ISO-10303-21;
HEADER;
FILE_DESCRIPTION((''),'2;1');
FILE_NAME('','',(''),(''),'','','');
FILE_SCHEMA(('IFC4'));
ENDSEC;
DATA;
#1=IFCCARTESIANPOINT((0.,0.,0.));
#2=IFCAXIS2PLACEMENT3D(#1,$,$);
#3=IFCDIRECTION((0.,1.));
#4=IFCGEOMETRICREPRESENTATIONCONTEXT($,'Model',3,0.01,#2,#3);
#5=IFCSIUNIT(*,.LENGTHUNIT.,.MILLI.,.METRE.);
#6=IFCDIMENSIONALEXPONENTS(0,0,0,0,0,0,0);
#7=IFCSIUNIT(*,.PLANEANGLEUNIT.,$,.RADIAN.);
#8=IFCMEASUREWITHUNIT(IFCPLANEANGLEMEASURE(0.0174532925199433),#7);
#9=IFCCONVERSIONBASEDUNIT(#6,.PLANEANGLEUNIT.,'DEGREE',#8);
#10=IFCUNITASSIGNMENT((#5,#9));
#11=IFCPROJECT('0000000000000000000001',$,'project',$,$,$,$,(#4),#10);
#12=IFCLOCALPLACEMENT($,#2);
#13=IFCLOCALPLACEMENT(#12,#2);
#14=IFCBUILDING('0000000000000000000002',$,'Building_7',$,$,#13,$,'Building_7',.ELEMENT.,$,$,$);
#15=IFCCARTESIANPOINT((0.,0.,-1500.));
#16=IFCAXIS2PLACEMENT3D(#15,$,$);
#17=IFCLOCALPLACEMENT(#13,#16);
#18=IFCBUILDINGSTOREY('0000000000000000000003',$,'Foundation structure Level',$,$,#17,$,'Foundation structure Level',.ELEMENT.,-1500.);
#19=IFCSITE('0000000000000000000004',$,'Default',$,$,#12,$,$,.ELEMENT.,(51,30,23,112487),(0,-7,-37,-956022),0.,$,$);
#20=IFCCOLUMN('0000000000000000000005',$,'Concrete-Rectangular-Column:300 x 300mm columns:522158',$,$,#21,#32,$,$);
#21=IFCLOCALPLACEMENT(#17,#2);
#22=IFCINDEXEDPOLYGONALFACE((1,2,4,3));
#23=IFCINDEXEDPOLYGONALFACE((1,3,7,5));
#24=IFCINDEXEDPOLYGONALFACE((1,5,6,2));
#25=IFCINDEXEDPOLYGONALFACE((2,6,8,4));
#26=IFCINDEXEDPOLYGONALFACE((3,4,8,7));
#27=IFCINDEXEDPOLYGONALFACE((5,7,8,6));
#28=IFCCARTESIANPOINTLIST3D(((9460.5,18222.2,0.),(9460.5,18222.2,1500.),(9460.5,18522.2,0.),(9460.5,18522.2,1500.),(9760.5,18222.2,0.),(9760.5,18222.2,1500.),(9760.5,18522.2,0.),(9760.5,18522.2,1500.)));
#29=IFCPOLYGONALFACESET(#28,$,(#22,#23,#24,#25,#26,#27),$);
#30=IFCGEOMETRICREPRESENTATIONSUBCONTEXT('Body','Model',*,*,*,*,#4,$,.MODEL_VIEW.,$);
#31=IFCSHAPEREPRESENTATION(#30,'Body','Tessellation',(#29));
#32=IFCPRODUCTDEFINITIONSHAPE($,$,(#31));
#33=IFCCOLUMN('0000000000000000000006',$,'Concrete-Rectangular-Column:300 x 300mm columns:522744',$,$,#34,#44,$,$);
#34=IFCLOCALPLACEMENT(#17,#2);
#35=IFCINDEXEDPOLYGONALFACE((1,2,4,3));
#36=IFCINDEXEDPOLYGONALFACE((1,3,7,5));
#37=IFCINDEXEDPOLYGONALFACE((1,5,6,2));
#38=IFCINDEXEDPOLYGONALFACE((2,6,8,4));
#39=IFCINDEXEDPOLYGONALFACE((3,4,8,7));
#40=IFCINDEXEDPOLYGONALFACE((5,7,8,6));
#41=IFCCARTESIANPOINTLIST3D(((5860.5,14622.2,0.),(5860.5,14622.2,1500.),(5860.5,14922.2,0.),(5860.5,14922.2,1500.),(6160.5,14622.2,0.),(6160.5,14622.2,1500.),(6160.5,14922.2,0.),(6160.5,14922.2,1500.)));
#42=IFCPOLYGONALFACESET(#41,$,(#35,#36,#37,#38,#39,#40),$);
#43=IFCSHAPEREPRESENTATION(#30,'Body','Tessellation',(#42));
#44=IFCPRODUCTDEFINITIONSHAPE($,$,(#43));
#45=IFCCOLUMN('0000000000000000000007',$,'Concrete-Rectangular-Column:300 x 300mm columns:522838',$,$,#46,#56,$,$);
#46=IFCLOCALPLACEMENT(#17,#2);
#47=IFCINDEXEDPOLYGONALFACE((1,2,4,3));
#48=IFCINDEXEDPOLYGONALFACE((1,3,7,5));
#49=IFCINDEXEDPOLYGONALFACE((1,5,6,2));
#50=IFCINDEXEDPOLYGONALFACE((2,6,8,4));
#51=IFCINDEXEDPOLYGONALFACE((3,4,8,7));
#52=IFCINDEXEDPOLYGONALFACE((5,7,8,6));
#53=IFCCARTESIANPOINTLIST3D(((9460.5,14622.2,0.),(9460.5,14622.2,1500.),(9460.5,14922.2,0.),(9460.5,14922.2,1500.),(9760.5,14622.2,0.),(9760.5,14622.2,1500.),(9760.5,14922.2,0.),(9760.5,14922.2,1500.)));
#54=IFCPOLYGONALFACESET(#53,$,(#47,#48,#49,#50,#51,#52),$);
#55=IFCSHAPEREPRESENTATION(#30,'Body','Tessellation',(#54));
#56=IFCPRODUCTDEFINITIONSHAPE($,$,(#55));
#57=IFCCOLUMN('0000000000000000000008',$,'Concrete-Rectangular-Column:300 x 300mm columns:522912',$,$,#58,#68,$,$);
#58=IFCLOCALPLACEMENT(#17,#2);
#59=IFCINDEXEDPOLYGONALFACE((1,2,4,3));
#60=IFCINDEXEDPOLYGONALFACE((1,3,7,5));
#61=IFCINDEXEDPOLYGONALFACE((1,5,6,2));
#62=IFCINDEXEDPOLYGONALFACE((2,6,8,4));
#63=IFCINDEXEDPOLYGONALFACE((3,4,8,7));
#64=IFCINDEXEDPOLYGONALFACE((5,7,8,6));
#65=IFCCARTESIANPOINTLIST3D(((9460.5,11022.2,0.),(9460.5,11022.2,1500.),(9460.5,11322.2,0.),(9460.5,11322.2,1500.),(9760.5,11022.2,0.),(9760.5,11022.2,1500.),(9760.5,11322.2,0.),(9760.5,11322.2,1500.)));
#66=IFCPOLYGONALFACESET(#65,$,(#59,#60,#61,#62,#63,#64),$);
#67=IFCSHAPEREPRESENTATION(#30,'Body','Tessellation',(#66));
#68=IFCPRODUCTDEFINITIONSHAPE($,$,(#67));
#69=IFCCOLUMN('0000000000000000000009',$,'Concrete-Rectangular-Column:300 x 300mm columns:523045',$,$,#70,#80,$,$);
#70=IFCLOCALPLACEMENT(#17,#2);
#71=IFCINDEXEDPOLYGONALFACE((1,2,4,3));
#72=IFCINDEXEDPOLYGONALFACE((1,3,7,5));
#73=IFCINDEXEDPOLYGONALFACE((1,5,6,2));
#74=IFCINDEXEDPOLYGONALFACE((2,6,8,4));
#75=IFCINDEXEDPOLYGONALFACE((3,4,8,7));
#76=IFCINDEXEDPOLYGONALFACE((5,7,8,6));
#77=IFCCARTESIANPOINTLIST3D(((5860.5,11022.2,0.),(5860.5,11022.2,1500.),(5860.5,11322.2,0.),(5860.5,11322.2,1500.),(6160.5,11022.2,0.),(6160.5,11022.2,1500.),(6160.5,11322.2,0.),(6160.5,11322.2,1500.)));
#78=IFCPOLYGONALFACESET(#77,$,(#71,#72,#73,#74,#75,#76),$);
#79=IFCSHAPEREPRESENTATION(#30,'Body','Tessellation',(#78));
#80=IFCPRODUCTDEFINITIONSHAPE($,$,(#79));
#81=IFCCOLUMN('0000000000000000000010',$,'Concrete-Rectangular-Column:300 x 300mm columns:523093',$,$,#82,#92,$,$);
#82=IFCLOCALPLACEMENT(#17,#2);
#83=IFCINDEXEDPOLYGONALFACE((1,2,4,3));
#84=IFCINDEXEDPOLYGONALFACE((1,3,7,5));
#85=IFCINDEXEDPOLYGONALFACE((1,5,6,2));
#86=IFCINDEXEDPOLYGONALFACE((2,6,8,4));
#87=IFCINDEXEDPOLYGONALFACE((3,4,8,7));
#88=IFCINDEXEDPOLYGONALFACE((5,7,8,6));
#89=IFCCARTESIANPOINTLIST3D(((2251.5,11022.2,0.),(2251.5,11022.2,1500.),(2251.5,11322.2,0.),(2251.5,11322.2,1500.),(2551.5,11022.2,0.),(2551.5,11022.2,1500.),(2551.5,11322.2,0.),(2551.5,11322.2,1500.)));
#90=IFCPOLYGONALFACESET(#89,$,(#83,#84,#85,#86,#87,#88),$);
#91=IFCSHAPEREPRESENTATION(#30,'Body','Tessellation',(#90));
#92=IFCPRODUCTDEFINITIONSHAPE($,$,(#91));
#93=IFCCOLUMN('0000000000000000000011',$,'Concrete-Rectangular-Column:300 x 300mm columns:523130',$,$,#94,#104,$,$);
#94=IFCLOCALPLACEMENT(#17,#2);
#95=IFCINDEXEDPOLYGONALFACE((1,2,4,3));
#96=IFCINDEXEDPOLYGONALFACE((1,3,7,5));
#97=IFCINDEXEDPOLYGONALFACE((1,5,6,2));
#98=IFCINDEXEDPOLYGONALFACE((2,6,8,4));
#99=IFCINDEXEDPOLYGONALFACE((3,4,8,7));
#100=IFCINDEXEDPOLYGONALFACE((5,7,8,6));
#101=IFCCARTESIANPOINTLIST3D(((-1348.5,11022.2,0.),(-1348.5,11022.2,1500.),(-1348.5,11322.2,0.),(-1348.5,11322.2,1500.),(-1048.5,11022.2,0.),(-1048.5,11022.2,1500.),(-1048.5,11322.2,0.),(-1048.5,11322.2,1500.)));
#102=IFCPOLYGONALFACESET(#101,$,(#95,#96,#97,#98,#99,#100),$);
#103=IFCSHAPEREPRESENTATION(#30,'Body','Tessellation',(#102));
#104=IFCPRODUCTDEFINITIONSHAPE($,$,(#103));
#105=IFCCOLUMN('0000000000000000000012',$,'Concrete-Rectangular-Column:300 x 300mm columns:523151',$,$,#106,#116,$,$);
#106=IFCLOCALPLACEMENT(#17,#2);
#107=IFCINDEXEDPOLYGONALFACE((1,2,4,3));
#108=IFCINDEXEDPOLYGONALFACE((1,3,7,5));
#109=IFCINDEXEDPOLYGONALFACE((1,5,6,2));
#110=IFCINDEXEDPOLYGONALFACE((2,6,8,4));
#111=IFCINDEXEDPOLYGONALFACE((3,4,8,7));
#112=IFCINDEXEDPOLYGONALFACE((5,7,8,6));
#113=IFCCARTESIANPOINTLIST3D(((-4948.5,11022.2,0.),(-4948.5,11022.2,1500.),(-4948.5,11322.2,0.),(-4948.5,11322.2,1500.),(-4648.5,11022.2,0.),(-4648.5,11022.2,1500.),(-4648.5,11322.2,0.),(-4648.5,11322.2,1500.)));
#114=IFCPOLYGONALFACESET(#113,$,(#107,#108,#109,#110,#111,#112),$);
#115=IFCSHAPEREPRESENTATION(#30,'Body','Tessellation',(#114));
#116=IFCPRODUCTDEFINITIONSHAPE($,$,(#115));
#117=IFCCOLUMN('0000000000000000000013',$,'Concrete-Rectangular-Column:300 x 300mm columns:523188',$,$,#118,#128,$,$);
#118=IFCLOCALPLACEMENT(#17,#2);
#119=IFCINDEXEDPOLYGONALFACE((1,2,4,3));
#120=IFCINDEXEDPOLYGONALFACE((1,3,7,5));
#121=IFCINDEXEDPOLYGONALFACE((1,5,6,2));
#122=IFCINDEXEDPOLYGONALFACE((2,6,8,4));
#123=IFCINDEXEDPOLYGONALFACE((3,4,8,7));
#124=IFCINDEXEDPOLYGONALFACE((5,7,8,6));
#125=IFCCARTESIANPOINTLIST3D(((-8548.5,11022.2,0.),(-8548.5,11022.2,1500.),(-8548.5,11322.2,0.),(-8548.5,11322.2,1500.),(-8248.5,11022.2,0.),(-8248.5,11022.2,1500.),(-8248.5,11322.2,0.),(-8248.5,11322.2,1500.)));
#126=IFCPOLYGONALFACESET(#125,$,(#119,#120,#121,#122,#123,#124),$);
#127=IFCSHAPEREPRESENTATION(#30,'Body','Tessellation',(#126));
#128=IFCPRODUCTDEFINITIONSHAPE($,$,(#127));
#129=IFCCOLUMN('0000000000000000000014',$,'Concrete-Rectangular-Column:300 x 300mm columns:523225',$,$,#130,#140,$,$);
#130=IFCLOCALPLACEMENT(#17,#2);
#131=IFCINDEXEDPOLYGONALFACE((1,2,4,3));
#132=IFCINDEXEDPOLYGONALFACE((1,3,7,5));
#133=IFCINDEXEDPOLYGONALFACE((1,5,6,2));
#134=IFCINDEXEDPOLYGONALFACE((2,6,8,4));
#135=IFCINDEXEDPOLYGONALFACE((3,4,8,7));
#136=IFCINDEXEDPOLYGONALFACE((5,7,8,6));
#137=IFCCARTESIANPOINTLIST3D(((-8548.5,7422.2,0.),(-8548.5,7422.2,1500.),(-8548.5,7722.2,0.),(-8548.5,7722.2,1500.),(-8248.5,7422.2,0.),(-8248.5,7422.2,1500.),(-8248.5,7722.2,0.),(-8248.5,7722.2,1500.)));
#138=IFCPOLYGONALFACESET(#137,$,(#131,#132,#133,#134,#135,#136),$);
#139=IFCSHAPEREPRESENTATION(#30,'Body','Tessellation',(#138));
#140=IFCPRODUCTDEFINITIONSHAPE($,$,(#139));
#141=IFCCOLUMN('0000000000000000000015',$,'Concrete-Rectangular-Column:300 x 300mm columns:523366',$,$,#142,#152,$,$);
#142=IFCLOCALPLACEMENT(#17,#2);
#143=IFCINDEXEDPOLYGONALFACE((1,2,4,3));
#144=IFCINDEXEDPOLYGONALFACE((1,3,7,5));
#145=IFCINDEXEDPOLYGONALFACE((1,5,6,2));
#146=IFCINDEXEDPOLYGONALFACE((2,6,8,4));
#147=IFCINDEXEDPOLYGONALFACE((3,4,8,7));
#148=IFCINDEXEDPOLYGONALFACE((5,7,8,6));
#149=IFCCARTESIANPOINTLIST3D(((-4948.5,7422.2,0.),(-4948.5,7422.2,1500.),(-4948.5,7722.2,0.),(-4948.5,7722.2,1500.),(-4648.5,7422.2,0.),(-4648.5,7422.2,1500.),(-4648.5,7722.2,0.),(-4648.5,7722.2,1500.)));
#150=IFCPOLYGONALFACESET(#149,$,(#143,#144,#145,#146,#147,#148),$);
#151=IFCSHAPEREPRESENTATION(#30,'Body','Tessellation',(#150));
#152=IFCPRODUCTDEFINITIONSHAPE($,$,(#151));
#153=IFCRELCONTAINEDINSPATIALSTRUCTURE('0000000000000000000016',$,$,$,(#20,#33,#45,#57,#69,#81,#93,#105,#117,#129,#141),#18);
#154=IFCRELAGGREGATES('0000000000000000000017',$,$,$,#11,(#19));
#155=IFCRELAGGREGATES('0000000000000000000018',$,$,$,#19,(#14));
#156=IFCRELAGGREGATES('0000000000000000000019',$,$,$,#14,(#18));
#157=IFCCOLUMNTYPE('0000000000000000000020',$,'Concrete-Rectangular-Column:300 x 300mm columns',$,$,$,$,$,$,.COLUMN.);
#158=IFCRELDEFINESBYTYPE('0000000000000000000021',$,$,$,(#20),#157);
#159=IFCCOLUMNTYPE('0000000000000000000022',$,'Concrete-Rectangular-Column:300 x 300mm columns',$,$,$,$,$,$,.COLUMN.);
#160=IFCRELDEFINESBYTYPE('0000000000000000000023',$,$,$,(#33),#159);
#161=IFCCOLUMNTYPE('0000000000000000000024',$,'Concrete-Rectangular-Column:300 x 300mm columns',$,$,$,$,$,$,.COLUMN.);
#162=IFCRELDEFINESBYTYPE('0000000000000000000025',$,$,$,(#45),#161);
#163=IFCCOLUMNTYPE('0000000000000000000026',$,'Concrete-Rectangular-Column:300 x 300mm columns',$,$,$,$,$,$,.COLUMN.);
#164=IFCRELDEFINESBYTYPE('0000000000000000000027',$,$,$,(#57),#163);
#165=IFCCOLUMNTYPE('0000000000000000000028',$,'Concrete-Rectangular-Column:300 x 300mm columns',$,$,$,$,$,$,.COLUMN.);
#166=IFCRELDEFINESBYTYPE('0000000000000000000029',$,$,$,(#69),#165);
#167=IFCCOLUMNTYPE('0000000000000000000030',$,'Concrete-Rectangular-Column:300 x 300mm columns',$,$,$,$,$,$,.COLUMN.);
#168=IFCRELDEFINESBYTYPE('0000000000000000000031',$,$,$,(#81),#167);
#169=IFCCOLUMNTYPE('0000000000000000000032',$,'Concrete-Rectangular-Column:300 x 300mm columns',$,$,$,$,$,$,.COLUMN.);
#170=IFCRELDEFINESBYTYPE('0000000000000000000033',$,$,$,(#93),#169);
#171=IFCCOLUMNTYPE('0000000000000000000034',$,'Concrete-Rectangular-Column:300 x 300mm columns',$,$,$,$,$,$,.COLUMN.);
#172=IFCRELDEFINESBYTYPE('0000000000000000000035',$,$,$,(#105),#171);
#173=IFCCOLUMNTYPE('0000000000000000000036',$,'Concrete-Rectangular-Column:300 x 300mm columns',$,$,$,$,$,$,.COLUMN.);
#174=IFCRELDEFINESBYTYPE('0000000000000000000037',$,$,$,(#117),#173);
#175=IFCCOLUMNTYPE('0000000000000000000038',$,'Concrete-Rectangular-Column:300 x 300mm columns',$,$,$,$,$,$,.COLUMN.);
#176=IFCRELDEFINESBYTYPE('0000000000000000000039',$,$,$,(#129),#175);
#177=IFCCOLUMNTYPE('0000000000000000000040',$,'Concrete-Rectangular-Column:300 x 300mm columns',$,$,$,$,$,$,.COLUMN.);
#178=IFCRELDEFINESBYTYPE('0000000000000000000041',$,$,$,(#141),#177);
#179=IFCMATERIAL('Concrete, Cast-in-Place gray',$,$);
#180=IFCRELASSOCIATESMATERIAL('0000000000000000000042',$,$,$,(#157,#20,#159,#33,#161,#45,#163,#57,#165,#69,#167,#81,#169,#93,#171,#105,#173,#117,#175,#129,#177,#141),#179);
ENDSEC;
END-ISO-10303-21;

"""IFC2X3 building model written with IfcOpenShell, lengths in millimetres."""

from ifc_helpers import new_model, entity, si_unit, converted_unit, direction, frame, frame_2d, origin, place, context, subcontext, project, spatial, rectangle, extrude, source, transform, mapped, material, type_object, type_shapes, element, save


model = new_model("IFC2X3")

# Units and contexts
model_context = context("Model", 3, precision=0.01, world=origin(), true_north=direction((0.0, 1.0)))
body_context = subcontext(model_context, "Body", "Model", "MODEL_VIEW")
ifc_project = project(units=[si_unit("LENGTHUNIT", "METRE", prefix="MILLI"), converted_unit("PLANEANGLEUNIT", "DEGREE", entity("IfcPlaneAngleMeasure", 0.0174532925199433), si_unit("PLANEANGLEUNIT", "RADIAN"), dimensions=[0, 0, 0, 0, 0, 0, 0])], contexts=[model_context])

# Site, building, storey
site_placement = place(None, origin())
site = spatial("IfcSite", under=ifc_project, at=site_placement, Name="Default", CompositionType="ELEMENT", RefLatitude=(51, 30, 23, 112487), RefLongitude=(0, -7, -37, -956022), RefElevation=0.0)
building_placement = place(site_placement, origin())
building = spatial("IfcBuilding", under=site, at=building_placement, Name="Building_7", LongName="Building_7", CompositionType="ELEMENT")
storey_placement = place(building_placement, frame((0.0, 0.0, -1500.0)))
storey = spatial("IfcBuildingStorey", under=building, at=storey_placement, Name="Foundation structure Level", LongName="Foundation structure Level", CompositionType="ELEMENT", Elevation=-1500.0)

# Columns
ifc_material_1 = material(Name="Concrete, Cast-in-Place gray")
column_type_1 = type_object("IfcColumnType", Name="Concrete-Rectangular-Column:300 x 300mm columns", PredefinedType="COLUMN", material=ifc_material_1)
shared_shape_1 = source(origin(), body_context, "Body", "SweptSolid", [
    extrude(rectangle(XDim=300.0, YDim=300.0, at=frame_2d((0.0, 0.0), x_axis=(1.0, 0.0))), frame((9610.5, 18372.2, -1500.0), z_axis=(0.0, 0.0, 1.0), x_axis=(-1.0, 0.0, 0.0)), (0.0, 0.0, 1.0), 1500.0),
])
type_shapes(column_type_1, [shared_shape_1])
column_1_placement = place(storey_placement, frame((0.0, 0.0, 1500.0)))
element("IfcColumn", 1, at=column_1_placement, inside=storey, type_object=column_type_1, material=ifc_material_1, Name="Concrete-Rectangular-Column:300 x 300mm columns:522158", context=body_context, shape_type="MappedRepresentation", body=[
    mapped(shared_shape_1, transform((0.0, 0.0, 0.0), scale=1.0)),
])
column_type_2 = type_object("IfcColumnType", Name="Concrete-Rectangular-Column:300 x 300mm columns", PredefinedType="COLUMN", material=ifc_material_1)
shared_shape_2 = source(origin(), body_context, "Body", "SweptSolid", [
    extrude(rectangle(XDim=300.0, YDim=300.0, at=frame_2d((0.0, 0.0), x_axis=(1.0, 0.0))), frame((6010.5, 14772.2, -1500.0), z_axis=(0.0, 0.0, 1.0), x_axis=(-1.0, 0.0, 0.0)), (0.0, 0.0, 1.0), 1500.0),
])
type_shapes(column_type_2, [shared_shape_2])
column_2_placement = place(storey_placement, frame((0.0, 0.0, 1500.0)))
element("IfcColumn", 2, at=column_2_placement, inside=storey, type_object=column_type_2, material=ifc_material_1, Name="Concrete-Rectangular-Column:300 x 300mm columns:522744", context=body_context, shape_type="MappedRepresentation", body=[
    mapped(shared_shape_2, transform((0.0, 0.0, 0.0), scale=1.0)),
])
column_type_3 = type_object("IfcColumnType", Name="Concrete-Rectangular-Column:300 x 300mm columns", PredefinedType="COLUMN", material=ifc_material_1)
shared_shape_3 = source(origin(), body_context, "Body", "SweptSolid", [
    extrude(rectangle(XDim=300.0, YDim=300.0, at=frame_2d((0.0, 0.0), x_axis=(1.0, 0.0))), frame((9610.5, 14772.2, -1500.0), z_axis=(0.0, 0.0, 1.0), x_axis=(-1.0, 0.0, 0.0)), (0.0, 0.0, 1.0), 1500.0),
])
type_shapes(column_type_3, [shared_shape_3])
column_3_placement = place(storey_placement, frame((0.0, 0.0, 1500.0)))
element("IfcColumn", 3, at=column_3_placement, inside=storey, type_object=column_type_3, material=ifc_material_1, Name="Concrete-Rectangular-Column:300 x 300mm columns:522838", context=body_context, shape_type="MappedRepresentation", body=[
    mapped(shared_shape_3, transform((0.0, 0.0, 0.0), scale=1.0)),
])
column_type_4 = type_object("IfcColumnType", Name="Concrete-Rectangular-Column:300 x 300mm columns", PredefinedType="COLUMN", material=ifc_material_1)
shared_shape_4 = source(origin(), body_context, "Body", "SweptSolid", [
    extrude(rectangle(XDim=300.0, YDim=300.0, at=frame_2d((0.0, 0.0), x_axis=(1.0, 0.0))), frame((9610.5, 11172.2, -1500.0), z_axis=(0.0, 0.0, 1.0), x_axis=(-1.0, 0.0, 0.0)), (0.0, 0.0, 1.0), 1500.0),
])
type_shapes(column_type_4, [shared_shape_4])
column_4_placement = place(storey_placement, frame((0.0, 0.0, 1500.0)))
element("IfcColumn", 4, at=column_4_placement, inside=storey, type_object=column_type_4, material=ifc_material_1, Name="Concrete-Rectangular-Column:300 x 300mm columns:522912", context=body_context, shape_type="MappedRepresentation", body=[
    mapped(shared_shape_4, transform((0.0, 0.0, 0.0), scale=1.0)),
])
column_type_5 = type_object("IfcColumnType", Name="Concrete-Rectangular-Column:300 x 300mm columns", PredefinedType="COLUMN", material=ifc_material_1)
shared_shape_5 = source(origin(), body_context, "Body", "SweptSolid", [
    extrude(rectangle(XDim=300.0, YDim=300.0, at=frame_2d((0.0, 0.0), x_axis=(1.0, 0.0))), frame((6010.5, 11172.2, -1500.0), z_axis=(0.0, 0.0, 1.0), x_axis=(-1.0, 0.0, 0.0)), (0.0, 0.0, 1.0), 1500.0),
])
type_shapes(column_type_5, [shared_shape_5])
column_5_placement = place(storey_placement, frame((0.0, 0.0, 1500.0)))
element("IfcColumn", 5, at=column_5_placement, inside=storey, type_object=column_type_5, material=ifc_material_1, Name="Concrete-Rectangular-Column:300 x 300mm columns:523045", context=body_context, shape_type="MappedRepresentation", body=[
    mapped(shared_shape_5, transform((0.0, 0.0, 0.0), scale=1.0)),
])
column_type_6 = type_object("IfcColumnType", Name="Concrete-Rectangular-Column:300 x 300mm columns", PredefinedType="COLUMN", material=ifc_material_1)
shared_shape_6 = source(origin(), body_context, "Body", "SweptSolid", [
    extrude(rectangle(XDim=300.0, YDim=300.0, at=frame_2d((0.0, 0.0), x_axis=(1.0, 0.0))), frame((2401.5, 11172.2, -1500.0), z_axis=(0.0, 0.0, 1.0), x_axis=(-1.0, 0.0, 0.0)), (0.0, 0.0, 1.0), 1500.0),
])
type_shapes(column_type_6, [shared_shape_6])
column_6_placement = place(storey_placement, frame((0.0, 0.0, 1500.0)))
element("IfcColumn", 6, at=column_6_placement, inside=storey, type_object=column_type_6, material=ifc_material_1, Name="Concrete-Rectangular-Column:300 x 300mm columns:523093", context=body_context, shape_type="MappedRepresentation", body=[
    mapped(shared_shape_6, transform((0.0, 0.0, 0.0), scale=1.0)),
])
column_type_7 = type_object("IfcColumnType", Name="Concrete-Rectangular-Column:300 x 300mm columns", PredefinedType="COLUMN", material=ifc_material_1)
shared_shape_7 = source(origin(), body_context, "Body", "SweptSolid", [
    extrude(rectangle(XDim=300.0, YDim=300.0, at=frame_2d((0.0, 0.0), x_axis=(1.0, 0.0))), frame((-1198.5, 11172.2, -1500.0), z_axis=(0.0, 0.0, 1.0), x_axis=(-1.0, 0.0, 0.0)), (0.0, 0.0, 1.0), 1500.0),
])
type_shapes(column_type_7, [shared_shape_7])
column_7_placement = place(storey_placement, frame((0.0, 0.0, 1500.0)))
element("IfcColumn", 7, at=column_7_placement, inside=storey, type_object=column_type_7, material=ifc_material_1, Name="Concrete-Rectangular-Column:300 x 300mm columns:523130", context=body_context, shape_type="MappedRepresentation", body=[
    mapped(shared_shape_7, transform((0.0, 0.0, 0.0), scale=1.0)),
])
column_type_8 = type_object("IfcColumnType", Name="Concrete-Rectangular-Column:300 x 300mm columns", PredefinedType="COLUMN", material=ifc_material_1)
shared_shape_8 = source(origin(), body_context, "Body", "SweptSolid", [
    extrude(rectangle(XDim=300.0, YDim=300.0, at=frame_2d((0.0, 0.0), x_axis=(1.0, 0.0))), frame((-4798.5, 11172.2, -1500.0), z_axis=(0.0, 0.0, 1.0), x_axis=(-1.0, 0.0, 0.0)), (0.0, 0.0, 1.0), 1500.0),
])
type_shapes(column_type_8, [shared_shape_8])
column_8_placement = place(storey_placement, frame((0.0, 0.0, 1500.0)))
element("IfcColumn", 8, at=column_8_placement, inside=storey, type_object=column_type_8, material=ifc_material_1, Name="Concrete-Rectangular-Column:300 x 300mm columns:523151", context=body_context, shape_type="MappedRepresentation", body=[
    mapped(shared_shape_8, transform((0.0, 0.0, 0.0), scale=1.0)),
])
column_type_9 = type_object("IfcColumnType", Name="Concrete-Rectangular-Column:300 x 300mm columns", PredefinedType="COLUMN", material=ifc_material_1)
shared_shape_9 = source(origin(), body_context, "Body", "SweptSolid", [
    extrude(rectangle(XDim=300.0, YDim=300.0, at=frame_2d((0.0, 0.0), x_axis=(1.0, 0.0))), frame((-8398.5, 11172.2, -1500.0), z_axis=(0.0, 0.0, 1.0), x_axis=(-1.0, 0.0, 0.0)), (0.0, 0.0, 1.0), 1500.0),
])
type_shapes(column_type_9, [shared_shape_9])
column_9_placement = place(storey_placement, frame((0.0, 0.0, 1500.0)))
element("IfcColumn", 9, at=column_9_placement, inside=storey, type_object=column_type_9, material=ifc_material_1, Name="Concrete-Rectangular-Column:300 x 300mm columns:523188", context=body_context, shape_type="MappedRepresentation", body=[
    mapped(shared_shape_9, transform((0.0, 0.0, 0.0), scale=1.0)),
])
column_type_10 = type_object("IfcColumnType", Name="Concrete-Rectangular-Column:300 x 300mm columns", PredefinedType="COLUMN", material=ifc_material_1)
shared_shape_10 = source(origin(), body_context, "Body", "SweptSolid", [
    extrude(rectangle(XDim=300.0, YDim=300.0, at=frame_2d((0.0, 0.0), x_axis=(1.0, 0.0))), frame((-8398.5, 7572.2, -1500.0), z_axis=(0.0, 0.0, 1.0), x_axis=(-1.0, 0.0, 0.0)), (0.0, 0.0, 1.0), 1500.0),
])
type_shapes(column_type_10, [shared_shape_10])
column_10_placement = place(storey_placement, frame((0.0, 0.0, 1500.0)))
element("IfcColumn", 10, at=column_10_placement, inside=storey, type_object=column_type_10, material=ifc_material_1, Name="Concrete-Rectangular-Column:300 x 300mm columns:523225", context=body_context, shape_type="MappedRepresentation", body=[
    mapped(shared_shape_10, transform((0.0, 0.0, 0.0), scale=1.0)),
])
column_type_11 = type_object("IfcColumnType", Name="Concrete-Rectangular-Column:300 x 300mm columns", PredefinedType="COLUMN", material=ifc_material_1)
shared_shape_11 = source(origin(), body_context, "Body", "SweptSolid", [
    extrude(rectangle(XDim=300.0, YDim=300.0, at=frame_2d((0.0, 0.0), x_axis=(1.0, 0.0))), frame((-4798.5, 7572.2, -1500.0), z_axis=(0.0, 0.0, 1.0), x_axis=(-1.0, 0.0, 0.0)), (0.0, 0.0, 1.0), 1500.0),
])
type_shapes(column_type_11, [shared_shape_11])
column_11_placement = place(storey_placement, frame((0.0, 0.0, 1500.0)))
element("IfcColumn", 11, at=column_11_placement, inside=storey, type_object=column_type_11, material=ifc_material_1, Name="Concrete-Rectangular-Column:300 x 300mm columns:523366", context=body_context, shape_type="MappedRepresentation", body=[
    mapped(shared_shape_11, transform((0.0, 0.0, 0.0), scale=1.0)),
])

save(model, "model.ifc")
